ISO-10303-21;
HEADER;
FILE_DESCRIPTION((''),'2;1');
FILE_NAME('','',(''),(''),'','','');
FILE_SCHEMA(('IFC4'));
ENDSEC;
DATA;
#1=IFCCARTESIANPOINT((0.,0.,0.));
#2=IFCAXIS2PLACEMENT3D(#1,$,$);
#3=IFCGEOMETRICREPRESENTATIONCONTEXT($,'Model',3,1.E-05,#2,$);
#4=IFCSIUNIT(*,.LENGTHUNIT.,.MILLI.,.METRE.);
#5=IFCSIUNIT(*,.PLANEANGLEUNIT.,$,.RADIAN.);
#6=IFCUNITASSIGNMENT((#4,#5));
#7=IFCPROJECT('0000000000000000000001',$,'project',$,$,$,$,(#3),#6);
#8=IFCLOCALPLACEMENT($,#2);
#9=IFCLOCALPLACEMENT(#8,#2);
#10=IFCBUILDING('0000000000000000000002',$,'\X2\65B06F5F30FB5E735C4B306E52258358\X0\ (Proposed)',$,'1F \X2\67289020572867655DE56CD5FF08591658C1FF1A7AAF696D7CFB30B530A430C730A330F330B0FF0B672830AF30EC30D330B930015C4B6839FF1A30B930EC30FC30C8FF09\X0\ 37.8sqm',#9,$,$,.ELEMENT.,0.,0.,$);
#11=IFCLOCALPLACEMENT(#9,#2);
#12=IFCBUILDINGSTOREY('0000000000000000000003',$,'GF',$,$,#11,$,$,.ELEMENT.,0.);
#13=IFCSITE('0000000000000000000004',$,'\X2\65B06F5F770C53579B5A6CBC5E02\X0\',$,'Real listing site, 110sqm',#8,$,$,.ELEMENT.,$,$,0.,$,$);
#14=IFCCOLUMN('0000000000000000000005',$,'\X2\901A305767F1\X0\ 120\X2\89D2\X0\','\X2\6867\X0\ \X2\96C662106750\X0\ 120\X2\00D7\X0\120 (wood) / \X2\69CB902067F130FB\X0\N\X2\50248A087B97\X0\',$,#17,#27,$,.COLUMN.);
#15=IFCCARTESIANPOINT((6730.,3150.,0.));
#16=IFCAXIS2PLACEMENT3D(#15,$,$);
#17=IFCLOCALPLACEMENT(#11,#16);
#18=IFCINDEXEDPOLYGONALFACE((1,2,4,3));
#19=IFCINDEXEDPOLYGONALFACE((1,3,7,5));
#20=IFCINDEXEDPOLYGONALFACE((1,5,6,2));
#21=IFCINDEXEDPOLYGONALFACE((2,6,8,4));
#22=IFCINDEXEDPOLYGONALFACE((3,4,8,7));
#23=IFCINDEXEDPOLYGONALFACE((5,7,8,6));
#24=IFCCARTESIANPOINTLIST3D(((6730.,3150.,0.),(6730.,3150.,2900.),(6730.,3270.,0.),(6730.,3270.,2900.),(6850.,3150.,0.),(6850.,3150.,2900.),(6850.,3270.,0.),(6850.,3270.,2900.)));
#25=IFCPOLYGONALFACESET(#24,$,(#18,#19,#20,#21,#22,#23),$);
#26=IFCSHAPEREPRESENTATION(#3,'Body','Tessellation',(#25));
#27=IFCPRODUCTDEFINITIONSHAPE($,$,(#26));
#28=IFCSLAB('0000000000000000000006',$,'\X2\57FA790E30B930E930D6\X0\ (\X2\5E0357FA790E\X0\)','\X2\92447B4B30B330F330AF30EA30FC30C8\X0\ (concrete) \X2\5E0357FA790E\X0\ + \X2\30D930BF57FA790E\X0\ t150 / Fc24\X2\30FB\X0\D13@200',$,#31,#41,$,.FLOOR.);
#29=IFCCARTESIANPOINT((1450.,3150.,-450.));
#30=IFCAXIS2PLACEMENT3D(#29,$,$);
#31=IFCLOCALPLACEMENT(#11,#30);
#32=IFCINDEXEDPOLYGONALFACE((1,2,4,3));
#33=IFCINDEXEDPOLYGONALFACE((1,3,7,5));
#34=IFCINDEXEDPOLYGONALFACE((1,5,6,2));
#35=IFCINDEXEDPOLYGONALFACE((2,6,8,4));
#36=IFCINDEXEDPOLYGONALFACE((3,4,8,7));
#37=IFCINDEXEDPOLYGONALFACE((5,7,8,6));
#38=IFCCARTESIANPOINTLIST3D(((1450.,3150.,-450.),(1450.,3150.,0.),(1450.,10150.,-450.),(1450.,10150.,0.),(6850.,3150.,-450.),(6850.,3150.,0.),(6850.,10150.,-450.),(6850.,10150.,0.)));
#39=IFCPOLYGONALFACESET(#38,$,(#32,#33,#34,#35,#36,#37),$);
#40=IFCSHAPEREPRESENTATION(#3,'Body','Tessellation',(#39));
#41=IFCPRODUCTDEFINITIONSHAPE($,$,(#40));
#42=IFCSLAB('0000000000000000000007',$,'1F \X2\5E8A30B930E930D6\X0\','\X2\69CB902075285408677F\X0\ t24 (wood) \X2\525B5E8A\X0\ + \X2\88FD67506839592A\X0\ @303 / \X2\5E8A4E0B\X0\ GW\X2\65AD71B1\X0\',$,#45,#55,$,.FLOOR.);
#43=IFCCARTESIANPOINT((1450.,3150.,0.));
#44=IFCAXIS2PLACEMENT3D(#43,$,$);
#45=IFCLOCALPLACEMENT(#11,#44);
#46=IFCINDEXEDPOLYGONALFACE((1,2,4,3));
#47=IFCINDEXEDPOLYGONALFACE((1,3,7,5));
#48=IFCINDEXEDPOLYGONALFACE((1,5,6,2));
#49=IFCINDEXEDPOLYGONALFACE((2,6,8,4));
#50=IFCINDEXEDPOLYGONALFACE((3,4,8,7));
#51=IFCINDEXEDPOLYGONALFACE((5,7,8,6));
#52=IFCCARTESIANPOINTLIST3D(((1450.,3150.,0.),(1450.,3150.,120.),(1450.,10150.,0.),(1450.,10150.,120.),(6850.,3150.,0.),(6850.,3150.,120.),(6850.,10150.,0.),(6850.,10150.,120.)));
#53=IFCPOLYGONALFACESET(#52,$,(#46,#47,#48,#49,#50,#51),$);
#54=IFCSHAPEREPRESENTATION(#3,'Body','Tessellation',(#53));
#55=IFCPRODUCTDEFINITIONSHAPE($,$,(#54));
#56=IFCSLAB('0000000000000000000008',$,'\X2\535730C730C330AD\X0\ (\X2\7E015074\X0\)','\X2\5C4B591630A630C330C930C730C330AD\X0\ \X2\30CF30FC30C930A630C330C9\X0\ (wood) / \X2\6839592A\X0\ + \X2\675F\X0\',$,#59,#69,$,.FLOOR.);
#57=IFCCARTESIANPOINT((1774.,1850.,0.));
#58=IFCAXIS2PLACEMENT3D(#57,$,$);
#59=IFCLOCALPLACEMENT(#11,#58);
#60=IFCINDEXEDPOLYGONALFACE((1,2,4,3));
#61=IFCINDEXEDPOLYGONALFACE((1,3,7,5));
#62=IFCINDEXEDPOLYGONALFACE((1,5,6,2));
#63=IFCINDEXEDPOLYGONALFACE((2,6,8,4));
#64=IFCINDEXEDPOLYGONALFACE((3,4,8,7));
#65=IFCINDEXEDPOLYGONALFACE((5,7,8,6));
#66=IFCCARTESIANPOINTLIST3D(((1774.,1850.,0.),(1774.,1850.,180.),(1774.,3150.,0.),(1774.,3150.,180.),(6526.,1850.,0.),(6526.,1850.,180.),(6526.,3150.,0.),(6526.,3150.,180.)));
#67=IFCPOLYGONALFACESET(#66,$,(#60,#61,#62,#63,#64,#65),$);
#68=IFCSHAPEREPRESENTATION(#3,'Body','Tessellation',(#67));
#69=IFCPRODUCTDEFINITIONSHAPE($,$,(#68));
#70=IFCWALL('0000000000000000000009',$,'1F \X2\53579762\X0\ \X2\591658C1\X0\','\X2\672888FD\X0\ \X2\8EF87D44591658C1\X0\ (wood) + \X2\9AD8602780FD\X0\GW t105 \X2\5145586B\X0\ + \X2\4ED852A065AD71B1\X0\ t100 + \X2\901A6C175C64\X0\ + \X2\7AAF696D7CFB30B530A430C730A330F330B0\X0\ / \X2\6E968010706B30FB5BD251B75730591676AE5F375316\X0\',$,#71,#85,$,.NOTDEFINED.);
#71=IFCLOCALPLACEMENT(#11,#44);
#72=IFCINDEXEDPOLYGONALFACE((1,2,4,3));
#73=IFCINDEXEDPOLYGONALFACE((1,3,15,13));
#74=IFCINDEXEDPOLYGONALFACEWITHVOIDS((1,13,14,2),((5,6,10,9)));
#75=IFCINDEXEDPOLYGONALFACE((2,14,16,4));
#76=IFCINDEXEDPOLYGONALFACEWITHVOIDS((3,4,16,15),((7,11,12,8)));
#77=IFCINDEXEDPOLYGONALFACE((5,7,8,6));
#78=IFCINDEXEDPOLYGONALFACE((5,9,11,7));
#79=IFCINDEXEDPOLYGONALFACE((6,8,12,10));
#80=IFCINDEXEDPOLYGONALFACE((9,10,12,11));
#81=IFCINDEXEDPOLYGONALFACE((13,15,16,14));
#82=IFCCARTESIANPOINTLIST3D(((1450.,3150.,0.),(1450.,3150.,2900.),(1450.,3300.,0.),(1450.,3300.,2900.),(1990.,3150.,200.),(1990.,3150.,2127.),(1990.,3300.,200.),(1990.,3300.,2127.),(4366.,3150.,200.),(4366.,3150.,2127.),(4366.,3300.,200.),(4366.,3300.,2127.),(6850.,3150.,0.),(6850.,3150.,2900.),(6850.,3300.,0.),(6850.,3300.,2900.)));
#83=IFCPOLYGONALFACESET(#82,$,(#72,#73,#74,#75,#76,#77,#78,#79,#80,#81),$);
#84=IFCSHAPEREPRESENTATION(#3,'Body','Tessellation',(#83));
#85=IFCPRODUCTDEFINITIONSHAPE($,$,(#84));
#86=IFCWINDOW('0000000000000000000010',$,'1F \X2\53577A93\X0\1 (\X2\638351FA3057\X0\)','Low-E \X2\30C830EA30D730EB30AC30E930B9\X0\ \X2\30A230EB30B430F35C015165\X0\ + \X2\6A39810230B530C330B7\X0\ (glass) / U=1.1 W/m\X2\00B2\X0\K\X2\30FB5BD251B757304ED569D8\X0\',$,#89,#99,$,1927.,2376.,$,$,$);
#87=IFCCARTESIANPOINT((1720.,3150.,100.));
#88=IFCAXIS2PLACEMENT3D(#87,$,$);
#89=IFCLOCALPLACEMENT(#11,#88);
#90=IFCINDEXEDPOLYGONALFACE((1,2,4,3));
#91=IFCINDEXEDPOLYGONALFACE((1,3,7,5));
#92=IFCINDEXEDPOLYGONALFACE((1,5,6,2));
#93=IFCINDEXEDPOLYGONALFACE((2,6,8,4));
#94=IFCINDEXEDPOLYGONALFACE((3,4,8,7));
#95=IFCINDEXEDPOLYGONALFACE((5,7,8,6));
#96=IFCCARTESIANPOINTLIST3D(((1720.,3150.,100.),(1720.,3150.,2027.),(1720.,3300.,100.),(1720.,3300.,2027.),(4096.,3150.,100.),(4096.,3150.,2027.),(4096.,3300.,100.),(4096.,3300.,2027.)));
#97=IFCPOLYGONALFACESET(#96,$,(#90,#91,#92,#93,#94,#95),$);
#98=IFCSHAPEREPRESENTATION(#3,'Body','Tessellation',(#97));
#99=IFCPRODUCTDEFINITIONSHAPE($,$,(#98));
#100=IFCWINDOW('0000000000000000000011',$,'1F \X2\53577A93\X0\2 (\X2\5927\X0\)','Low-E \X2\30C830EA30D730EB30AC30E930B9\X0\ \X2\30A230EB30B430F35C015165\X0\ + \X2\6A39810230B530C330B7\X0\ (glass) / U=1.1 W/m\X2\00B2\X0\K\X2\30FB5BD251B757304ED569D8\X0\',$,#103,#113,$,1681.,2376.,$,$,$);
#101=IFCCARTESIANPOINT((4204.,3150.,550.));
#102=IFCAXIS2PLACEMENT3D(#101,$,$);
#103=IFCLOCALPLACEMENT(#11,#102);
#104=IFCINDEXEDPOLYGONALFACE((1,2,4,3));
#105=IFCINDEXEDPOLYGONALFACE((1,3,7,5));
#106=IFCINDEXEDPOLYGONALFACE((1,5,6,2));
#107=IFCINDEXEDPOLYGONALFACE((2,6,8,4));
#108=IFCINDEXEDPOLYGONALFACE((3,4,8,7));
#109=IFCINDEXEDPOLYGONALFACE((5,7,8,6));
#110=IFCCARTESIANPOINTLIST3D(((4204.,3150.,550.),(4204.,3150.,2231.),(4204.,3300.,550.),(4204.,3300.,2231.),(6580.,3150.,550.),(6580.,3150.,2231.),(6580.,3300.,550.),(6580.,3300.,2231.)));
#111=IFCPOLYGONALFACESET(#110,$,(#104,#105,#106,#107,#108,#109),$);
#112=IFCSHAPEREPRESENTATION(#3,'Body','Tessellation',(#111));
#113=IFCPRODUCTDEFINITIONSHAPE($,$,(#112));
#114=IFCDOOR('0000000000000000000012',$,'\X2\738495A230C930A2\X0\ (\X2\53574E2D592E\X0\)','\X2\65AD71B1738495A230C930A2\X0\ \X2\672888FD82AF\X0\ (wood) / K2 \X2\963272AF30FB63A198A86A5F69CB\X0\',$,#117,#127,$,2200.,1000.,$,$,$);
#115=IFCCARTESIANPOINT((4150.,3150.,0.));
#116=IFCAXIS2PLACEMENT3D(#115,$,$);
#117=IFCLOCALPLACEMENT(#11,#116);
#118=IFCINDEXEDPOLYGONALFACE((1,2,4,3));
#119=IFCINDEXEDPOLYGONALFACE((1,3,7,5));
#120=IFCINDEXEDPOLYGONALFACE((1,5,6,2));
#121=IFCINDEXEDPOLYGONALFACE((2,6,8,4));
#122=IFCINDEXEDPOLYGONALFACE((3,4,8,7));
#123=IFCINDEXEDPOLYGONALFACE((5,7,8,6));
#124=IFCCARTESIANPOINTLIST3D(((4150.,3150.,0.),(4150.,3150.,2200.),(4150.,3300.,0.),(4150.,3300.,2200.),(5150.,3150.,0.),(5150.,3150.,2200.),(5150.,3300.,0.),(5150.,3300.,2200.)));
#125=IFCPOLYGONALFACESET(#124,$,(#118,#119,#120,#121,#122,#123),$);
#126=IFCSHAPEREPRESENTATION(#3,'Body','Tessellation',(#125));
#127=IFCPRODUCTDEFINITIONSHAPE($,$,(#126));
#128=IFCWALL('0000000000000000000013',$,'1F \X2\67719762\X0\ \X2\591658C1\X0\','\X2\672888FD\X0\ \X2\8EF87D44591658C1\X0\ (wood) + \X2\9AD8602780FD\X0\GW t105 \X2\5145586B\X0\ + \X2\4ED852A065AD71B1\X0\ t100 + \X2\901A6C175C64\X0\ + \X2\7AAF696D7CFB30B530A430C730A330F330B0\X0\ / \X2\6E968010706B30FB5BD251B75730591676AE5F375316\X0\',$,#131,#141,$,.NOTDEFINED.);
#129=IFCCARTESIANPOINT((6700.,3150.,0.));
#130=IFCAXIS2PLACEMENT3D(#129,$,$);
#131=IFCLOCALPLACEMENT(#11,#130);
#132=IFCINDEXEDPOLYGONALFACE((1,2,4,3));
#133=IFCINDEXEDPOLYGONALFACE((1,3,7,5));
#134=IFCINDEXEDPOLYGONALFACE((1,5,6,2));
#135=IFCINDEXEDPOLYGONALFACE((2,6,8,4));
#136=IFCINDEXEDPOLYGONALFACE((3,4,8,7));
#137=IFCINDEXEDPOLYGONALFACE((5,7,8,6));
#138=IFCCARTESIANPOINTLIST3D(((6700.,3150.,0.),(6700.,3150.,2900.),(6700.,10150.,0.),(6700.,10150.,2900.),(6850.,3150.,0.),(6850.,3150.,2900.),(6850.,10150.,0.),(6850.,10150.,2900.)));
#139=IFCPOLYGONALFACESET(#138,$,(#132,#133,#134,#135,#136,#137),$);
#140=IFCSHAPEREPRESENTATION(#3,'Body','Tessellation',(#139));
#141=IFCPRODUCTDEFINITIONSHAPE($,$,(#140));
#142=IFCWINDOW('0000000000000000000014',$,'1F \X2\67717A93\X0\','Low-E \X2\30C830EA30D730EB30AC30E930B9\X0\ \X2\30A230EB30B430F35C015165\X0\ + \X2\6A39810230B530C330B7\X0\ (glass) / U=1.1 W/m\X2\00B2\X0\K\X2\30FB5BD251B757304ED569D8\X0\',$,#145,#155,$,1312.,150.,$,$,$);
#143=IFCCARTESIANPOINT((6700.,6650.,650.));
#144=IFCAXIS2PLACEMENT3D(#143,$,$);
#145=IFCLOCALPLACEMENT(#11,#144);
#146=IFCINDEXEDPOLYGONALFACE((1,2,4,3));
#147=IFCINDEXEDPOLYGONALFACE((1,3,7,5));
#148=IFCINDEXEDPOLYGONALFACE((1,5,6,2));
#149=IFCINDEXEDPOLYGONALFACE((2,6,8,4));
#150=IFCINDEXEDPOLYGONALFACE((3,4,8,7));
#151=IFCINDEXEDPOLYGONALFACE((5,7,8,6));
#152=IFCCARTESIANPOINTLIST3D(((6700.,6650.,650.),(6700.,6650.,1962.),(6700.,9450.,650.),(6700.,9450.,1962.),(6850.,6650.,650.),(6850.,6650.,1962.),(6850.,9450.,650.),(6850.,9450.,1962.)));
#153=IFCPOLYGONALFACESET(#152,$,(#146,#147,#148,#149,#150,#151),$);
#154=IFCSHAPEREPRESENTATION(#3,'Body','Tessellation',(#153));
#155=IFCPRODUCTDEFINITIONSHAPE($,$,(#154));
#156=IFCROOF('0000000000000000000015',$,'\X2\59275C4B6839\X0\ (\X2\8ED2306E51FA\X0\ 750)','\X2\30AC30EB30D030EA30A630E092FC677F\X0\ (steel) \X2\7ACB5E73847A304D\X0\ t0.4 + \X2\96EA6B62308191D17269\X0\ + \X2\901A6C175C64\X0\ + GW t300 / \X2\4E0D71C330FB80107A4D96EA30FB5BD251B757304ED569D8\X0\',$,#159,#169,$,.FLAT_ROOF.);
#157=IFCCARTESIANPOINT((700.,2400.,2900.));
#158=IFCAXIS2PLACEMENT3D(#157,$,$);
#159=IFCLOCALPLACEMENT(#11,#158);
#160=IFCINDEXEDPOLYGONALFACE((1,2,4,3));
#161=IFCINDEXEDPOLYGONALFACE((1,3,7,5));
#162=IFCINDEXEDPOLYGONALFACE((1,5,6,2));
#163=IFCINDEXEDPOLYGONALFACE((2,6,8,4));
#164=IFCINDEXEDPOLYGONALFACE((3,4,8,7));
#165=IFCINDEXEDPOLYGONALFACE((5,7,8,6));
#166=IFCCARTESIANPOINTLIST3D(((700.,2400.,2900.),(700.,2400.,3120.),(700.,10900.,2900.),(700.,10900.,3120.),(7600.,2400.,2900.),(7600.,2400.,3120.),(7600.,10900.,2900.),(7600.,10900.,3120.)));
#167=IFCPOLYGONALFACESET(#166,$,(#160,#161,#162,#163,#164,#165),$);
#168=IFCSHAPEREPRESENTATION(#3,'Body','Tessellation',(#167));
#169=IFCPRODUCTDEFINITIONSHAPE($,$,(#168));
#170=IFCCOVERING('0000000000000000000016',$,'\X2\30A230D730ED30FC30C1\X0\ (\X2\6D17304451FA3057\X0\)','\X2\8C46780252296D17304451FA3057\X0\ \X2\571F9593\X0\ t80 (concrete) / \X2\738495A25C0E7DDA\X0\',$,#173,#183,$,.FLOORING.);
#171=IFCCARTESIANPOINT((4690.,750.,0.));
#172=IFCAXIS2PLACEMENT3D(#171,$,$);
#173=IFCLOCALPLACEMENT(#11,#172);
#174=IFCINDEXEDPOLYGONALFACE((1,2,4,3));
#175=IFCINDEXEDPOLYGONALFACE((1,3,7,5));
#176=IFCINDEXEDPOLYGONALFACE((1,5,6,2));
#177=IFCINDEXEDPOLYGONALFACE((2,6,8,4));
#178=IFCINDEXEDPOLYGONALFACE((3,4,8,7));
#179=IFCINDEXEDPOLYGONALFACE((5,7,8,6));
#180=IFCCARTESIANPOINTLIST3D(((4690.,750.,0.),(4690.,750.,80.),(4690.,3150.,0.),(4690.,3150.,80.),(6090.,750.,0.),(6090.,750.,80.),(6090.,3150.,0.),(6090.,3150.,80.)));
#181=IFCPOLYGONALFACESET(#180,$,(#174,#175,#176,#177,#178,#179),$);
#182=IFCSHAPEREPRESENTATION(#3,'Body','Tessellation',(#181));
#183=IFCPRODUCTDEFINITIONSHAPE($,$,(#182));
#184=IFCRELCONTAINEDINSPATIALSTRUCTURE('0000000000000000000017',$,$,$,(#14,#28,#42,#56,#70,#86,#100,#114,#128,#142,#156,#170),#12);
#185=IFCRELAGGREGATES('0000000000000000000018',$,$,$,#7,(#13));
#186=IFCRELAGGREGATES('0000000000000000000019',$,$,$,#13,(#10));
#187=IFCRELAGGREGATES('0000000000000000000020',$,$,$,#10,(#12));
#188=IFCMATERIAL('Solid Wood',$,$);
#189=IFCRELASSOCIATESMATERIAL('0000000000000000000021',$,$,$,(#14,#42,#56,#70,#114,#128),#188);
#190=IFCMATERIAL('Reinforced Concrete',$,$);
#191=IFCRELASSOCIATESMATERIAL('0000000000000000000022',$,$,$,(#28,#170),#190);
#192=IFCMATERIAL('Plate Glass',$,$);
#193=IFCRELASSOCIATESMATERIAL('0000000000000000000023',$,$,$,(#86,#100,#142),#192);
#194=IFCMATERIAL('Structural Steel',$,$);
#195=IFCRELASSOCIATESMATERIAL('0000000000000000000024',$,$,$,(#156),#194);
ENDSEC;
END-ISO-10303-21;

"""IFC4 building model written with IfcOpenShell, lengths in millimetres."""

from ifc_helpers import new_model, si_unit, frame, frame_2d, origin, place, context, project, spatial, rectangle, extrude, material, element, fill, save


model = new_model("IFC4")

# Units and contexts
model_context = context("Model", 3, precision=1e-05, world=origin())
ifc_project = project(units=[si_unit("LENGTHUNIT", "METRE", prefix="MILLI"), si_unit("PLANEANGLEUNIT", "RADIAN")], contexts=[model_context])

# Site, building, storey
site_placement = place(None, origin())
site = spatial("IfcSite", under=ifc_project, at=site_placement, Name="新潟県南魚沼市", ObjectType="Real listing site, 110sqm", CompositionType="ELEMENT", RefElevation=0.0)
building_placement = place(site_placement, origin())
building = spatial("IfcBuilding", under=site, at=building_placement, Name="新潟・平屋の別荘 (Proposed)", ObjectType="1F 木造在来工法（外壁：窯業系サイディング＋木クレビス、屋根：スレート） 37.8sqm", CompositionType="ELEMENT", ElevationOfRefHeight=0.0, ElevationOfTerrain=0.0)
storey_placement = place(building_placement, origin())
storey = spatial("IfcBuildingStorey", under=building, at=storey_placement, Name="GF", CompositionType="ELEMENT", Elevation=0.0)

# Column
ifc_material_1 = material(Name="Solid Wood")
column_1_placement = place(storey_placement, frame((6730.0, 3150.0, 0.0)))
element("IfcColumn", 1, at=column_1_placement, inside=storey, material=ifc_material_1, Name="通し柱 120角", Description="桧 集成材 120×120 (wood) / 構造柱・N値計算", PredefinedType="COLUMN", context=model_context, shape_type="SweptSolid", body=[
    extrude(rectangle(XDim=120.0, YDim=120.0, at=frame_2d((60.0, 60.0))), frame((6730.0, 3150.0, 0.0)), (0.0, 0.0, 1.0), 2900.0),
])

# Slabs
ifc_material_2 = material(Name="Reinforced Concrete")
slab_1_placement = place(storey_placement, frame((1450.0, 3150.0, -450.0)))
element("IfcSlab", 2, at=slab_1_placement, inside=storey, material=ifc_material_2, Name="基礎スラブ (布基礎)", Description="鉄筋コンクリート (concrete) 布基礎 + ベタ基礎 t150 / Fc24・D13@200", PredefinedType="FLOOR", context=model_context, shape_type="SweptSolid", body=[
    extrude(rectangle(XDim=5400.0, YDim=7000.0, at=frame_2d((2700.0, 3500.0))), frame((1450.0, 3150.0, -450.0)), (0.0, 0.0, 1.0), 450.0),
])
slab_2_placement = place(storey_placement, frame((1450.0, 3150.0, 0.0)))
element("IfcSlab", 3, at=slab_2_placement, inside=storey, material=ifc_material_1, Name="1F 床スラブ", Description="構造用合板 t24 (wood) 剛床 + 製材根太 @303 / 床下 GW断熱", PredefinedType="FLOOR", context=model_context, shape_type="SweptSolid", body=[
    extrude(rectangle(XDim=5400.0, YDim=7000.0, at=frame_2d((2700.0, 3500.0))), frame((1450.0, 3150.0, 0.0)), (0.0, 0.0, 1.0), 120.0),
])
slab_3_placement = place(storey_placement, frame((1774.0, 1850.0, 0.0)))
element("IfcSlab", 4, at=slab_3_placement, inside=storey, material=ifc_material_1, Name="南デッキ (縁側)", Description="屋外ウッドデッキ ハードウッド (wood) / 根太 + 束", PredefinedType="FLOOR", context=model_context, shape_type="SweptSolid", body=[
    extrude(rectangle(XDim=4752.0, YDim=1300.0, at=frame_2d((2376.0, 650.0))), frame((1774.0, 1850.0, 0.0)), (0.0, 0.0, 1.0), 180.0),
])

# Wall, openings, windows, door
wall_1_placement = place(storey_placement, frame((1450.0, 3150.0, 0.0)))
wall_1 = element("IfcWall", 5, at=wall_1_placement, inside=storey, material=ifc_material_1, Name="1F 南面 外壁", Description="木製 軸組外壁 (wood) + 高性能GW t105 充填 + 付加断熱 t100 + 通気層 + 窯業系サイディング / 準耐火・寒冷地外皮強化", PredefinedType="NOTDEFINED", context=model_context, shape_type="SweptSolid", body=[
    extrude(rectangle(XDim=5400.0, YDim=150.0, at=frame_2d((2700.0, 75.0))), frame((1450.0, 3150.0, 0.0)), (0.0, 0.0, 1.0), 2900.0),
])
opening_1_placement = place(storey_placement, frame((1720.0, 3150.0, 100.0)))
opening_1 = element("IfcOpeningElement", 6, at=opening_1_placement, cuts=wall_1, PredefinedType="NOTDEFINED", context=model_context, shape_type="SweptSolid", body=[
    extrude(rectangle(XDim=2376.0, YDim=150.0, at=frame_2d((1188.0, 75.0))), frame((1720.0, 3150.0, 100.0)), (0.0, 0.0, 1.0), 1927.0),
])
opening_2_placement = place(storey_placement, frame((4204.0, 3150.0, 550.0)))
opening_2 = element("IfcOpeningElement", 7, at=opening_2_placement, cuts=wall_1, PredefinedType="NOTDEFINED", context=model_context, shape_type="SweptSolid", body=[
    extrude(rectangle(XDim=2376.0, YDim=150.0, at=frame_2d((1188.0, 75.0))), frame((4204.0, 3150.0, 550.0)), (0.0, 0.0, 1.0), 1681.0),
])
opening_3_placement = place(storey_placement, frame((4150.0, 3150.0, 0.0)))
opening_3 = element("IfcOpeningElement", 8, at=opening_3_placement, cuts=wall_1, PredefinedType="NOTDEFINED", context=model_context, shape_type="SweptSolid", body=[
    extrude(rectangle(XDim=1000.0, YDim=150.0, at=frame_2d((500.0, 75.0))), frame((4150.0, 3150.0, 0.0)), (0.0, 0.0, 1.0), 2200.0),
])
ifc_material_3 = material(Name="Plate Glass")
window_1_placement = place(storey_placement, frame((1720.0, 3150.0, 100.0)))
window_1 = element("IfcWindow", 9, at=window_1_placement, inside=storey, material=ifc_material_3, Name="1F 南窓1 (掃出し)", Description="Low-E トリプルガラス アルゴン封入 + 樹脂サッシ (glass) / U=1.1 W/m²K・寒冷地仕様", OverallHeight=1927.0, OverallWidth=2376.0, context=model_context, shape_type="SweptSolid", body=[
    extrude(rectangle(XDim=2376.0, YDim=150.0, at=frame_2d((1188.0, 75.0))), frame((1720.0, 3150.0, 100.0)), (0.0, 0.0, 1.0), 1927.0),
])
fill(opening_1, window_1)
window_2_placement = place(storey_placement, frame((4204.0, 3150.0, 550.0)))
window_2 = element("IfcWindow", 10, at=window_2_placement, inside=storey, material=ifc_material_3, Name="1F 南窓2 (大)", Description="Low-E トリプルガラス アルゴン封入 + 樹脂サッシ (glass) / U=1.1 W/m²K・寒冷地仕様", OverallHeight=1681.0, OverallWidth=2376.0, context=model_context, shape_type="SweptSolid", body=[
    extrude(rectangle(XDim=2376.0, YDim=150.0, at=frame_2d((1188.0, 75.0))), frame((4204.0, 3150.0, 550.0)), (0.0, 0.0, 1.0), 1681.0),
])
fill(opening_2, window_2)
door_placement = place(storey_placement, frame((4150.0, 3150.0, 0.0)))
door = element("IfcDoor", 11, at=door_placement, inside=storey, material=ifc_material_1, Name="玄関ドア (南中央)", Description="断熱玄関ドア 木製芯 (wood) / K2 防犯・採風機構", OverallHeight=2200.0, OverallWidth=1000.0, context=model_context, shape_type="SweptSolid", body=[
    extrude(rectangle(XDim=1000.0, YDim=150.0, at=frame_2d((500.0, 75.0))), frame((4150.0, 3150.0, 0.0)), (0.0, 0.0, 1.0), 2200.0),
])
fill(opening_3, door)

# Wall, opening, window
wall_2_placement = place(storey_placement, frame((6700.0, 3150.0, 0.0)))
wall_2 = element("IfcWall", 12, at=wall_2_placement, inside=storey, material=ifc_material_1, Name="1F 東面 外壁", Description="木製 軸組外壁 (wood) + 高性能GW t105 充填 + 付加断熱 t100 + 通気層 + 窯業系サイディング / 準耐火・寒冷地外皮強化", PredefinedType="NOTDEFINED", context=model_context, shape_type="SweptSolid", body=[
    extrude(rectangle(XDim=150.0, YDim=7000.0, at=frame_2d((75.0, 3500.0))), frame((6700.0, 3150.0, 0.0)), (0.0, 0.0, 1.0), 2900.0),
])
opening_4_placement = place(storey_placement, frame((6700.0, 6650.0, 650.0)))
opening_4 = element("IfcOpeningElement", 13, at=opening_4_placement, cuts=wall_2, PredefinedType="NOTDEFINED", context=model_context, shape_type="SweptSolid", body=[
    extrude(rectangle(XDim=150.0, YDim=2800.0, at=frame_2d((75.0, 1400.0))), frame((6700.0, 6650.0, 650.0)), (0.0, 0.0, 1.0), 1312.0),
])
window_3_placement = place(storey_placement, frame((6700.0, 6650.0, 650.0)))
window_3 = element("IfcWindow", 14, at=window_3_placement, inside=storey, material=ifc_material_3, Name="1F 東窓", Description="Low-E トリプルガラス アルゴン封入 + 樹脂サッシ (glass) / U=1.1 W/m²K・寒冷地仕様", OverallHeight=1312.0, OverallWidth=150.0, context=model_context, shape_type="SweptSolid", body=[
    extrude(rectangle(XDim=150.0, YDim=2800.0, at=frame_2d((75.0, 1400.0))), frame((6700.0, 6650.0, 650.0)), (0.0, 0.0, 1.0), 1312.0),
])
fill(opening_4, window_3)

# Roof
ifc_material_4 = material(Name="Structural Steel")
roof_placement = place(storey_placement, frame((700.0, 2400.0, 2900.0)))
element("IfcRoof", 15, at=roof_placement, inside=storey, material=ifc_material_4, Name="大屋根 (軒の出 750)", Description="ガルバリウム鋼板 (steel) 立平葺き t0.4 + 雪止め金物 + 通気層 + GW t300 / 不燃・耐積雪・寒冷地仕様", PredefinedType="FLAT_ROOF", context=model_context, shape_type="SweptSolid", body=[
    extrude(rectangle(XDim=6900.0, YDim=8500.0, at=frame_2d((3450.0, 4250.0))), frame((700.0, 2400.0, 2900.0)), (0.0, 0.0, 1.0), 220.0),
])

# Covering
covering_1_placement = place(storey_placement, frame((4690.0, 750.0, 0.0)))
element("IfcCovering", 16, at=covering_1_placement, inside=storey, material=ifc_material_2, Name="アプローチ (洗い出し)", Description="豆砂利洗い出し 土間 t80 (concrete) / 玄関導線", PredefinedType="FLOORING", context=model_context, shape_type="SweptSolid", body=[
    extrude(rectangle(XDim=1400.0, YDim=2400.0, at=frame_2d((700.0, 1200.0))), frame((4690.0, 750.0, 0.0)), (0.0, 0.0, 1.0), 80.0),
])

save(model, "model.ifc")
